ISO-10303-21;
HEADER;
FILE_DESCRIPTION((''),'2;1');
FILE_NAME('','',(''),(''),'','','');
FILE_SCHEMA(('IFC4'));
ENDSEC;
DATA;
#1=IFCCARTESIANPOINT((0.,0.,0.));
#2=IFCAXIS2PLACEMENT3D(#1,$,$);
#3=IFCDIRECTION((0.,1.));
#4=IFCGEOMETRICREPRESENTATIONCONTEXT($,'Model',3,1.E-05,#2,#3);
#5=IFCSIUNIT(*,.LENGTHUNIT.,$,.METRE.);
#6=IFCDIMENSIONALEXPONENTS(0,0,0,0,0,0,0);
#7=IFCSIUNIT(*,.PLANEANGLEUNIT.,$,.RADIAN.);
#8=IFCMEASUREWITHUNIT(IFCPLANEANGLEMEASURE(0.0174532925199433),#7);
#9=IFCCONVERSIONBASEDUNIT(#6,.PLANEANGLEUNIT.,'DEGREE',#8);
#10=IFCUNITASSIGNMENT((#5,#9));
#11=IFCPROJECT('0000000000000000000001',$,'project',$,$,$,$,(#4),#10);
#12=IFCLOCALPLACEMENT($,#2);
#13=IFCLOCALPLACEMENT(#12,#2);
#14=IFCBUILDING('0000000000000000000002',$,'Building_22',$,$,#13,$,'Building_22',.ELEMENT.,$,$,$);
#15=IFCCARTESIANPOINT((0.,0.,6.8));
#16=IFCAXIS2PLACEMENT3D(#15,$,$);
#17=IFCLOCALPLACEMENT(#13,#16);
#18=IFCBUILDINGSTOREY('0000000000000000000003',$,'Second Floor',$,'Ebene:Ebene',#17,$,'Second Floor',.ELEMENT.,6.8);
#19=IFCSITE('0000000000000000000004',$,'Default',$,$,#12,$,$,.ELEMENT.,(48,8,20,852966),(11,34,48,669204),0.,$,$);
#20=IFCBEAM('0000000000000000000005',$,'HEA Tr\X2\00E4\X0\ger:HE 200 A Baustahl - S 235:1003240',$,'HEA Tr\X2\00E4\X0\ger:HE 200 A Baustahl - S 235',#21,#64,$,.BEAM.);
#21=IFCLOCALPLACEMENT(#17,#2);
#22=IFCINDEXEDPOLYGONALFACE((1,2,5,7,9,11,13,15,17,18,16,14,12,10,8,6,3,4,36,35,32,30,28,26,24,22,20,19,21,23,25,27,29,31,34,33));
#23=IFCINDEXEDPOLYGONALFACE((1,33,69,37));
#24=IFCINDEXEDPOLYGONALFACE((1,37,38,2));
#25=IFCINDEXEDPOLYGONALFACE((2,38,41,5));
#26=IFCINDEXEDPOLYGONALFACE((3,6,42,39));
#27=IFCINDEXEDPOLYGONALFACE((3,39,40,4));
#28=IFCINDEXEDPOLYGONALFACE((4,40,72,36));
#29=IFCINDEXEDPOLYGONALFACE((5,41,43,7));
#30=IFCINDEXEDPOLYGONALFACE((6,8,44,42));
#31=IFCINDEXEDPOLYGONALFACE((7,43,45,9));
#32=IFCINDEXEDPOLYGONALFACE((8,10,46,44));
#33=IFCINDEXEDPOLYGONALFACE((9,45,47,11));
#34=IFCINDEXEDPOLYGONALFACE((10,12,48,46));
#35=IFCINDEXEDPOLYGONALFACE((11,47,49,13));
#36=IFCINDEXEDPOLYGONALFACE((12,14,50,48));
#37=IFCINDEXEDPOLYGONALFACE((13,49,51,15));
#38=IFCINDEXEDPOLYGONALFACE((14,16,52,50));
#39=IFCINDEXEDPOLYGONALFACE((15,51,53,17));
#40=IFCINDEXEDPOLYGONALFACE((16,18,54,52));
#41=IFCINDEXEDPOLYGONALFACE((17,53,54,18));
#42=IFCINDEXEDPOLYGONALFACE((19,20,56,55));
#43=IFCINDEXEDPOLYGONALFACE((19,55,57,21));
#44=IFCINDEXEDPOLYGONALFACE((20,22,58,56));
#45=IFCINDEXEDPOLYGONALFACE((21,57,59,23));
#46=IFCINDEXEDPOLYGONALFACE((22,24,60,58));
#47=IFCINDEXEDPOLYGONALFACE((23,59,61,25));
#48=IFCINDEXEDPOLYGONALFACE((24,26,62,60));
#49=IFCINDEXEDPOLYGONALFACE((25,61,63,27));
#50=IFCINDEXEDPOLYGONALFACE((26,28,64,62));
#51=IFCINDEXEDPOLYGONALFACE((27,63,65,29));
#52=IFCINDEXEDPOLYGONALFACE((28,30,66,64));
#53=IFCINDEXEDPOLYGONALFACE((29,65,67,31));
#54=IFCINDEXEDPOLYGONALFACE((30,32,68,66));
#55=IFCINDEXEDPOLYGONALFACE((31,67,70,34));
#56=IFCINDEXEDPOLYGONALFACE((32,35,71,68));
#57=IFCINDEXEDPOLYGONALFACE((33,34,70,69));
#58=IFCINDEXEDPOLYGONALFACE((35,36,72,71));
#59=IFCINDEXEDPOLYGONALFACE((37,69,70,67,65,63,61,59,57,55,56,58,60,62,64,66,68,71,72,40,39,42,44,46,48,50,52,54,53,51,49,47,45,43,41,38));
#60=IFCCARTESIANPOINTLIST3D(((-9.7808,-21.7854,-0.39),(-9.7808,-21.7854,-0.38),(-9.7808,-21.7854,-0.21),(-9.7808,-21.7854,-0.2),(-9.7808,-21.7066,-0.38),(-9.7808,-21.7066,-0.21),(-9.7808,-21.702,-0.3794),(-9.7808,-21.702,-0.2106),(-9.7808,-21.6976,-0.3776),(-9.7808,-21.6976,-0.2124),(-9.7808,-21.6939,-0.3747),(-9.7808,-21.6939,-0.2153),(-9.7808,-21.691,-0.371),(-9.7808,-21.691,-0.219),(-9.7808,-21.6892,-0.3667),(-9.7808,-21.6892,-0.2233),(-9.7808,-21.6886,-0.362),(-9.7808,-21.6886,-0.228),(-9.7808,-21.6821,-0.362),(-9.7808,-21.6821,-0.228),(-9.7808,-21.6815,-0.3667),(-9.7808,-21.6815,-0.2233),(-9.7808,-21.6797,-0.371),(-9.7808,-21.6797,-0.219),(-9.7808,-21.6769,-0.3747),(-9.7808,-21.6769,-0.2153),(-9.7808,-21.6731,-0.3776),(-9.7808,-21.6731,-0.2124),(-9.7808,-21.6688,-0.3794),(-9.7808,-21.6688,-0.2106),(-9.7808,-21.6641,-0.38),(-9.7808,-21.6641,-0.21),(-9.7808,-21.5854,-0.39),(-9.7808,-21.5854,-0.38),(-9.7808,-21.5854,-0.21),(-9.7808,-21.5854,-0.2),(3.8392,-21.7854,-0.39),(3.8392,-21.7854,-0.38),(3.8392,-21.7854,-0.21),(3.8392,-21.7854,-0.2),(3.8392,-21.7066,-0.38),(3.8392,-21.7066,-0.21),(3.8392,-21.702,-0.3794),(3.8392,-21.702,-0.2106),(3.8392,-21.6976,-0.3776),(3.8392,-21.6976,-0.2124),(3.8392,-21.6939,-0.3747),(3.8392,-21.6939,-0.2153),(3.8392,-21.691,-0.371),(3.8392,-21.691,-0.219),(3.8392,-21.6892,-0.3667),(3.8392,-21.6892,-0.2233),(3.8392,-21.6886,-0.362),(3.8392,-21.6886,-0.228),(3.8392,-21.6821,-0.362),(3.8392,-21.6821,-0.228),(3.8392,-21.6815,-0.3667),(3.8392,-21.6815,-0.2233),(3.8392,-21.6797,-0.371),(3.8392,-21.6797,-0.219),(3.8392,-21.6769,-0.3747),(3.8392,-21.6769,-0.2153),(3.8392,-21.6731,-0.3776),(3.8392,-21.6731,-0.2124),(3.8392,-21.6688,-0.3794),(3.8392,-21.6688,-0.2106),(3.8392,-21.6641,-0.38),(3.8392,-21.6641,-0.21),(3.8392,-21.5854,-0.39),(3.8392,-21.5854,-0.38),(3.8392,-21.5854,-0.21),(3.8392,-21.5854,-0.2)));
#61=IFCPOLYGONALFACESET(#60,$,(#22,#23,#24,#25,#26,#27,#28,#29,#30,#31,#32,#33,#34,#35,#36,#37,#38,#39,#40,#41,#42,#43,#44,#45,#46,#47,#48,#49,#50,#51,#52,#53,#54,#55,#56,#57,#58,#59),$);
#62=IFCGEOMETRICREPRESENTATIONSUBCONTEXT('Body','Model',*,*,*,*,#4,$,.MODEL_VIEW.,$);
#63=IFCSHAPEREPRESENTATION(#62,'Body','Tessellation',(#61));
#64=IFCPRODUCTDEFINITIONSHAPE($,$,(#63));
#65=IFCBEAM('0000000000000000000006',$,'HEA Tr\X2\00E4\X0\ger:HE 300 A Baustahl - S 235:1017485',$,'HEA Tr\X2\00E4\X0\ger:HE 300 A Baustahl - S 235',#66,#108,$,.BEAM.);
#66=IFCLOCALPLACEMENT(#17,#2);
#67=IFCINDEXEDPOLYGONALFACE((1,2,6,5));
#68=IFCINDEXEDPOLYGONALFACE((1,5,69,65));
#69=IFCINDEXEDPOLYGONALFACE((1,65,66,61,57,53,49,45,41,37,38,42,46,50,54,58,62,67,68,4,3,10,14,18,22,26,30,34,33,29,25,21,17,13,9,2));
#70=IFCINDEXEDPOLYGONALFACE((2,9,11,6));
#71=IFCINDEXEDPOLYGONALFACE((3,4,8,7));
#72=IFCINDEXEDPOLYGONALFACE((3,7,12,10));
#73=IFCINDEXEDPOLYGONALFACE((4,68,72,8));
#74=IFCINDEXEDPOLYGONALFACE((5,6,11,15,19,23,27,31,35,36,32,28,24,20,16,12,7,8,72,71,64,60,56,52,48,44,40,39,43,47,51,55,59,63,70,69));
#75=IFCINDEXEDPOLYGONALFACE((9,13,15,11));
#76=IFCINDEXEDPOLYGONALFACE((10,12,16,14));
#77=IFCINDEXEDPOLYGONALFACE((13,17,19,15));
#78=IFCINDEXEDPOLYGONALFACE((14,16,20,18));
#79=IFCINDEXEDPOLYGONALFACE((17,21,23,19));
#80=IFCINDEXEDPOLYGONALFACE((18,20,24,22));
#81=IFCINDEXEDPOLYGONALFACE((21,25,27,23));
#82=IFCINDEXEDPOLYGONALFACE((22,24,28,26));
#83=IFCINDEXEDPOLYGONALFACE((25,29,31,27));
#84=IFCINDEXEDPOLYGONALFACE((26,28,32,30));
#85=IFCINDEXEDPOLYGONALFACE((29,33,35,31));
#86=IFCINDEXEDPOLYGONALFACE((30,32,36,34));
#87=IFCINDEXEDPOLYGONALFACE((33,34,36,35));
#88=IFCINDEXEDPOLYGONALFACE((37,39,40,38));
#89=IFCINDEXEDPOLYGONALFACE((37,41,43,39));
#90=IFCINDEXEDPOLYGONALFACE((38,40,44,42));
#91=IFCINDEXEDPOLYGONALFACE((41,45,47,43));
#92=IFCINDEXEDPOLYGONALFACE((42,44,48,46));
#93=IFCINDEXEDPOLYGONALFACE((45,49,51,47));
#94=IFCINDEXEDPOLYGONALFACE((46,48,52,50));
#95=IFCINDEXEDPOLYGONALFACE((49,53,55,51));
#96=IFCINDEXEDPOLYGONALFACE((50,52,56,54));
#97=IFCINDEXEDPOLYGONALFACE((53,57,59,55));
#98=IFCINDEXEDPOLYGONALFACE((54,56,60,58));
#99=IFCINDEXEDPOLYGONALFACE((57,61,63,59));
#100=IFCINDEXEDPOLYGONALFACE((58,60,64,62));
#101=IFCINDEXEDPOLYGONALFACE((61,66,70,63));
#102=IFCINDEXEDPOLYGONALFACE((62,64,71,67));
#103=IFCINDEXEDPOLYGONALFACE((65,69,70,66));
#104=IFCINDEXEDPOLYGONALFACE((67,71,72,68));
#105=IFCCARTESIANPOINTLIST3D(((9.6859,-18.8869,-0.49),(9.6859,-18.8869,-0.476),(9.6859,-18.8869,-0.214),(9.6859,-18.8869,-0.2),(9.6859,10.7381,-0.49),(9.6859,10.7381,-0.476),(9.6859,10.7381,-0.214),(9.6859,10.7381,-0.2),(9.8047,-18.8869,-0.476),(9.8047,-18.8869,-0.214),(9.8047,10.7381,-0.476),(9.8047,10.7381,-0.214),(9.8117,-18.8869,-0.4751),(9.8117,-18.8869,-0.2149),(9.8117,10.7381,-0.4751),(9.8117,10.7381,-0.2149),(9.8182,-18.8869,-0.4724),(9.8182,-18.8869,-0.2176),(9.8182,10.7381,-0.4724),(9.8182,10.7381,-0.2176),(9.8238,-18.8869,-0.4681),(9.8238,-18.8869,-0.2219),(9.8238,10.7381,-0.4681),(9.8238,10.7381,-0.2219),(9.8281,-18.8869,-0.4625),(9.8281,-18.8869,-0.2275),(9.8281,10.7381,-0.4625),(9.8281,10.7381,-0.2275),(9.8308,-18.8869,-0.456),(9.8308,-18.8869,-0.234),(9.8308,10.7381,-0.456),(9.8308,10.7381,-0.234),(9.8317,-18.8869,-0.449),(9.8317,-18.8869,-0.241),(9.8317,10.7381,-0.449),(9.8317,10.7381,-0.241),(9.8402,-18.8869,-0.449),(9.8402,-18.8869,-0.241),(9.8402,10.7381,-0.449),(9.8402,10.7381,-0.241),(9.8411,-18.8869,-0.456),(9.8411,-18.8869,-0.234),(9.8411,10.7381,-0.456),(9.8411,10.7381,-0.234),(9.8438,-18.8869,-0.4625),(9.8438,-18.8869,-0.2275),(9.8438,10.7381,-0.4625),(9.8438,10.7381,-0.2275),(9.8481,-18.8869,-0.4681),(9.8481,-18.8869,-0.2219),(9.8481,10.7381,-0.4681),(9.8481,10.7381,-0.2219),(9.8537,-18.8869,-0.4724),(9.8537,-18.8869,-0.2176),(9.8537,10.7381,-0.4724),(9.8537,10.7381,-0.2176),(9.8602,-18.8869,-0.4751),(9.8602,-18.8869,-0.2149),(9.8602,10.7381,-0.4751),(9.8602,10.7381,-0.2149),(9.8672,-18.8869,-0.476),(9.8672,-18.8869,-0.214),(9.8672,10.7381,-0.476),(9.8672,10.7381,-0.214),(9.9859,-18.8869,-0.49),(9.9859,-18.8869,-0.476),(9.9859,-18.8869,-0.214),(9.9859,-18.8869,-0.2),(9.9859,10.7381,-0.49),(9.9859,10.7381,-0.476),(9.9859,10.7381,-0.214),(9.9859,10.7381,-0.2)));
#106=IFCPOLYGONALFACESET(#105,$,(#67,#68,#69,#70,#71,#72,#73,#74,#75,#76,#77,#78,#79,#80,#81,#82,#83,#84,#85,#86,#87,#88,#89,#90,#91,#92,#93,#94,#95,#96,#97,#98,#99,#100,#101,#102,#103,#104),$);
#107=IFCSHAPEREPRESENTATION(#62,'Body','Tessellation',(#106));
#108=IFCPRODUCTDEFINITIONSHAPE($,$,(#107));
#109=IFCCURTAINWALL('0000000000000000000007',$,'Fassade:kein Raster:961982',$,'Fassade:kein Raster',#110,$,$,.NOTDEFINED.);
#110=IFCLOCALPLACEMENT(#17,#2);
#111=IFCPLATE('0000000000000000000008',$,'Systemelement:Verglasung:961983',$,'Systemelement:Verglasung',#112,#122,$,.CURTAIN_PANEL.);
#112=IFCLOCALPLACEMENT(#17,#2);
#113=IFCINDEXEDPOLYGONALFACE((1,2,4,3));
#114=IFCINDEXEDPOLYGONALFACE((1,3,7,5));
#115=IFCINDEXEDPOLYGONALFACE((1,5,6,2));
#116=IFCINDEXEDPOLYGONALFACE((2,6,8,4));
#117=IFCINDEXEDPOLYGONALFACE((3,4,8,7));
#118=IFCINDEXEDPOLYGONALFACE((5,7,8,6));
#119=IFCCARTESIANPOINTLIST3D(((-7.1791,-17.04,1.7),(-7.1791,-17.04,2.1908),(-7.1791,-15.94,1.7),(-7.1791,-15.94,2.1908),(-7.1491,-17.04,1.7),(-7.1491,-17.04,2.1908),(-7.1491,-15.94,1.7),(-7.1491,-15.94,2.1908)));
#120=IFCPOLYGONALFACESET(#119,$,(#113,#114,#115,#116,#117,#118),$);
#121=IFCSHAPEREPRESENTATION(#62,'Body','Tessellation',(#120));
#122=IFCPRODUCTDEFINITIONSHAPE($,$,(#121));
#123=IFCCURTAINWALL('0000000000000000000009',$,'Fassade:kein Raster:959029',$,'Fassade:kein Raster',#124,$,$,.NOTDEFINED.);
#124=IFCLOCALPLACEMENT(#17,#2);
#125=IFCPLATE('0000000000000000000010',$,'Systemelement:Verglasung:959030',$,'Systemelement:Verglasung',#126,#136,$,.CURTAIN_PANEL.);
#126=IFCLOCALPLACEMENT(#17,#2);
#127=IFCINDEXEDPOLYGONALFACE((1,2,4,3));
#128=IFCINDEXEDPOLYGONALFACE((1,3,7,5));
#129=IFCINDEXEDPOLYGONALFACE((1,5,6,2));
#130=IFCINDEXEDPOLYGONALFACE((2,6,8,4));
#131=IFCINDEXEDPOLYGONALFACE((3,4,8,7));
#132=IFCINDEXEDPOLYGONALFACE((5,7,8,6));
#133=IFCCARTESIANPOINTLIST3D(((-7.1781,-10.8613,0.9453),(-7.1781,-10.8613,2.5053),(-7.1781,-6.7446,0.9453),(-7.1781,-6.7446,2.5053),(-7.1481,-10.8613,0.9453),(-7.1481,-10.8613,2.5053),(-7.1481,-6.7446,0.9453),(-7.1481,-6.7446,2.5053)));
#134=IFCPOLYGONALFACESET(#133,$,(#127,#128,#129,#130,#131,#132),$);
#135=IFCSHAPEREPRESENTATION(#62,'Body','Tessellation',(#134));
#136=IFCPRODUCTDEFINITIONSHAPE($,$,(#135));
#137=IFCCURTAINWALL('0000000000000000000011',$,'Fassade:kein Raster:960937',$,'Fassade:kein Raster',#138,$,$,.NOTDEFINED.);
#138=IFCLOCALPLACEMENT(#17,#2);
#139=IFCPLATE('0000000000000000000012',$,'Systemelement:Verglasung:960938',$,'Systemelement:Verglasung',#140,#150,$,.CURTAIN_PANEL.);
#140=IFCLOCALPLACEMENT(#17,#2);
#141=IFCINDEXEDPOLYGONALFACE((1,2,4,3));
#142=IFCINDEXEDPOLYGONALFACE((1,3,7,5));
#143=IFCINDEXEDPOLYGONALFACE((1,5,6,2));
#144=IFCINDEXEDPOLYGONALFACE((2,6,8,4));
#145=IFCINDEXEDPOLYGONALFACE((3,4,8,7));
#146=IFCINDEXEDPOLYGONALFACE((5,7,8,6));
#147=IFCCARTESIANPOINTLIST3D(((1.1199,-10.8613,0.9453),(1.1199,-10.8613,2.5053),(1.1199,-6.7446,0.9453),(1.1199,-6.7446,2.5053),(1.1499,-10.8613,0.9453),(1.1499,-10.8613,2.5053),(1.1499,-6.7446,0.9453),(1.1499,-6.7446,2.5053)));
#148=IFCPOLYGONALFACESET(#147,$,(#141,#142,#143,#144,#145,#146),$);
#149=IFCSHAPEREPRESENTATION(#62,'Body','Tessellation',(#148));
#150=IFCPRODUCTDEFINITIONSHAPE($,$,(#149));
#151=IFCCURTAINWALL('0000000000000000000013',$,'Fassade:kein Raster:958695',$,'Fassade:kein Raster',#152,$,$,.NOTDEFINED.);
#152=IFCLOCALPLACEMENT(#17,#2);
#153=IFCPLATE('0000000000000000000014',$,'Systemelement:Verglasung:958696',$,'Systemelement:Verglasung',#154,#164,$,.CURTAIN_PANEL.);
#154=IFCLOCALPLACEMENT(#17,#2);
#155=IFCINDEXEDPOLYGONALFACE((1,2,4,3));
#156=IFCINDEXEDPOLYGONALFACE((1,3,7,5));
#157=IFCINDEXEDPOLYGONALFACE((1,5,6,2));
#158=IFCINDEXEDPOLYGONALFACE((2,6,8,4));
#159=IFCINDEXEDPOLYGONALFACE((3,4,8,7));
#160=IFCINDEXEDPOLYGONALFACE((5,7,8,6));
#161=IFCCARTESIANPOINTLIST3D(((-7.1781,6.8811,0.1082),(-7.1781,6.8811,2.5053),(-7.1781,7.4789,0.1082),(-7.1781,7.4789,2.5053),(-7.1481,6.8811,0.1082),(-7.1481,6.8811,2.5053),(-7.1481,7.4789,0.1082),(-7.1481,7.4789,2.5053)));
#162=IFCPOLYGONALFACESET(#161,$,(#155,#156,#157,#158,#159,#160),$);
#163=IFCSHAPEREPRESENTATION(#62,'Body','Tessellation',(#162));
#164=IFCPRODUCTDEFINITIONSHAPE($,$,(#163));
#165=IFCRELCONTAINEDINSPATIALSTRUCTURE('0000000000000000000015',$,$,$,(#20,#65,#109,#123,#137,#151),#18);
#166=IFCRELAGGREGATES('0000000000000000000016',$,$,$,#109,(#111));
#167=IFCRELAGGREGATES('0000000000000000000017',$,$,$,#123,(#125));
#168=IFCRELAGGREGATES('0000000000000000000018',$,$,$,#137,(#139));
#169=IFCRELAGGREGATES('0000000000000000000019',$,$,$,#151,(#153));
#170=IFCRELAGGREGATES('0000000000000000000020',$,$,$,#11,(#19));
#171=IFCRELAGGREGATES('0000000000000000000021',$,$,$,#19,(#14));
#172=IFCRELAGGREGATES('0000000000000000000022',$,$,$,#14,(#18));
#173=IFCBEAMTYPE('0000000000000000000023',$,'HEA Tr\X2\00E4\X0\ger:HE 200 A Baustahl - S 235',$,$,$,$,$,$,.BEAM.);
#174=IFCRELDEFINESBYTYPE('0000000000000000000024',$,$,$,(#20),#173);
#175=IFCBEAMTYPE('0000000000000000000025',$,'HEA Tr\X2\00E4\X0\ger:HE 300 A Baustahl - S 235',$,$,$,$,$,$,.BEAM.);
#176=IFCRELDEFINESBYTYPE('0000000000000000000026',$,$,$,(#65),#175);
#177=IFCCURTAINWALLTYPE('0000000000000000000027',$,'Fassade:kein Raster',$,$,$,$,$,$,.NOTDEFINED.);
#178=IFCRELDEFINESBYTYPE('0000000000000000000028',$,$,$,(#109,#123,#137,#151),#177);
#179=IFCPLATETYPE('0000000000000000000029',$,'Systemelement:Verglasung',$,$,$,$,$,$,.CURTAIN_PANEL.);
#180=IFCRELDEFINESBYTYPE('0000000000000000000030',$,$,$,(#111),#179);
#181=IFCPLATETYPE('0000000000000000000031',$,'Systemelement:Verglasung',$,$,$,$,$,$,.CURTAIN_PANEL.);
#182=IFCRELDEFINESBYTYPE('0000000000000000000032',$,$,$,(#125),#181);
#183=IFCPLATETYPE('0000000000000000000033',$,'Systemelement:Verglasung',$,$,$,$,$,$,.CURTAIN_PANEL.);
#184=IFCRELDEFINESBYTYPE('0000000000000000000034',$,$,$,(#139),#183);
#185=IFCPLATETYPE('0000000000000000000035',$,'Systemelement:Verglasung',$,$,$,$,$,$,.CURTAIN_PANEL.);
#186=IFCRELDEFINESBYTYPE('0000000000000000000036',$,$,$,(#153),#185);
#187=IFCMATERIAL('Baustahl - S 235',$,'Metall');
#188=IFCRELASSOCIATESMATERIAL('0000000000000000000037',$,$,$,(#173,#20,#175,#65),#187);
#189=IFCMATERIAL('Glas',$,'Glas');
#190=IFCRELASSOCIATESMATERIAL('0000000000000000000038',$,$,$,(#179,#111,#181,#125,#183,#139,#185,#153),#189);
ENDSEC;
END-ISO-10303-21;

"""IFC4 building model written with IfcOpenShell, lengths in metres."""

from ifc_helpers import new_model, entity, si_unit, converted_unit, direction, frame, origin, place, context, subcontext, project, spatial, line, arc, indexed_curve, outline, extrude, source, transform, mapped, material, type_object, type_shapes, element, aggregate, save


model = new_model("IFC4")

# Units and contexts
model_context = context("Model", 3, precision=1e-05, world=origin(), true_north=direction((0.0, 1.0)))
body_context = subcontext(model_context, "Body", "Model", "MODEL_VIEW")
ifc_project = project(units=[si_unit("LENGTHUNIT", "METRE"), converted_unit("PLANEANGLEUNIT", "DEGREE", entity("IfcPlaneAngleMeasure", 0.0174532925199433), si_unit("PLANEANGLEUNIT", "RADIAN"), dimensions=[0, 0, 0, 0, 0, 0, 0])], contexts=[model_context])

# Site, building, storey
site_placement = place(None, origin())
site = spatial("IfcSite", under=ifc_project, at=site_placement, Name="Default", CompositionType="ELEMENT", RefLatitude=(48, 8, 20, 852966), RefLongitude=(11, 34, 48, 669204), RefElevation=0.0)
building_placement = place(site_placement, origin())
building = spatial("IfcBuilding", under=site, at=building_placement, Name="Building_22", LongName="Building_22", CompositionType="ELEMENT")
storey_placement = place(building_placement, frame((0.0, 0.0, 6.8)))
storey = spatial("IfcBuildingStorey", under=building, at=storey_placement, Name="Second Floor", ObjectType="Ebene:Ebene", LongName="Second Floor", CompositionType="ELEMENT", Elevation=6.8)

# Beams
ifc_material_1 = material(Name="Baustahl - S 235", Category="Metall")
beam_type_1 = type_object("IfcBeamType", Name="HEA Träger:HE 200 A Baustahl - S 235", PredefinedType="BEAM", material=ifc_material_1)
shared_shape_1 = source(origin(), body_context, "Body", "SweptSolid", [
    extrude(outline(indexed_curve([(-0.1, -0.085), (-0.1, -0.095), (0.1, -0.095), (0.1, -0.085), (0.0213, -0.085), (0.0085, -0.0797), (0.0033, -0.067), (0.0033, 0.067), (0.0085, 0.0797), (0.0213, 0.085), (0.1, 0.085), (0.1, 0.095), (-0.1, 0.095), (-0.1, 0.085), (-0.0213, 0.085), (-0.0085, 0.0797), (-0.0033, 0.067), (-0.0033, -0.067), (-0.0085, -0.0797), (-0.0213, -0.085)], segments=[line(1, 2, 3, 4, 5), arc(5, 6, 7), line(7, 8), arc(8, 9, 10), line(10, 11, 12, 13, 14, 15), arc(15, 16, 17), line(17, 18), arc(18, 19, 20), line(20, 1)], self_intersect=False)), frame((-6.81, 0.0, 0.0), z_axis=(-1.0, 0.0, 0.0), x_axis=(0.0, -1.0, 0.0)), (0.0, 0.0, -1.0), 13.62),
])
type_shapes(beam_type_1, [shared_shape_1])
beam_1_placement = place(storey_placement, frame((-2.9708, -21.6854, -0.295)))
element("IfcBeam", 1, at=beam_1_placement, inside=storey, type_object=beam_type_1, material=ifc_material_1, Name="HEA Träger:HE 200 A Baustahl - S 235:1003240", ObjectType="HEA Träger:HE 200 A Baustahl - S 235", PredefinedType="BEAM", context=body_context, shape_type="MappedRepresentation", body=[
    mapped(shared_shape_1, transform((0.0, 0.0, 0.0), scale=1.0)),
])
beam_type_2 = type_object("IfcBeamType", Name="HEA Träger:HE 300 A Baustahl - S 235", PredefinedType="BEAM", material=ifc_material_1)
shared_shape_2 = source(origin(), body_context, "Body", "SweptSolid", [
    extrude(outline(indexed_curve([(0.131, -0.15), (0.145, -0.15), (0.145, 0.15), (0.131, 0.15), (0.131, 0.0313), (0.1231, 0.0122), (0.104, 0.0043), (-0.104, 0.0043), (-0.1231, 0.0122), (-0.131, 0.0313), (-0.131, 0.15), (-0.145, 0.15), (-0.145, -0.15), (-0.131, -0.15), (-0.131, -0.0313), (-0.1231, -0.0122), (-0.104, -0.0043), (0.104, -0.0043), (0.1231, -0.0122), (0.131, -0.0313)], segments=[line(1, 2, 3, 4, 5), arc(5, 6, 7), line(7, 8), arc(8, 9, 10), line(10, 11, 12, 13, 14, 15), arc(15, 16, 17), line(17, 18), arc(18, 19, 20), line(20, 1)], self_intersect=False)), frame((-14.8125, 0.0, 0.0), z_axis=(1.0, 0.0, 0.0), x_axis=(0.0, 0.0, -1.0)), (0.0, 0.0, 1.0), 29.625),
])
type_shapes(beam_type_2, [shared_shape_2])
beam_2_placement = place(storey_placement, frame((9.8359, -4.0744, -0.345), z_axis=(0.0, 0.0, 1.0), x_axis=(0.0, -1.0, 0.0)))
element("IfcBeam", 2, at=beam_2_placement, inside=storey, type_object=beam_type_2, material=ifc_material_1, Name="HEA Träger:HE 300 A Baustahl - S 235:1017485", ObjectType="HEA Träger:HE 300 A Baustahl - S 235", PredefinedType="BEAM", context=body_context, shape_type="MappedRepresentation", body=[
    mapped(shared_shape_2, transform((0.0, 0.0, 0.0), scale=1.0)),
])

# Curtain walls, plates
curtain_wall_type_1 = type_object("IfcCurtainWallType", Name="Fassade:kein Raster", PredefinedType="NOTDEFINED")
curtain_wall_1_placement = place(storey_placement, frame((0.0, 0.0, -6.8)))
curtain_wall_1 = element("IfcCurtainWall", 3, at=curtain_wall_1_placement, inside=storey, type_object=curtain_wall_type_1, Name="Fassade:kein Raster:961982", ObjectType="Fassade:kein Raster", PredefinedType="NOTDEFINED")
ifc_material_2 = material(Name="Glas", Category="Glas")
plate_type_1 = type_object("IfcPlateType", Name="Systemelement:Verglasung", PredefinedType="CURTAIN_PANEL", material=ifc_material_2)
shared_shape_3 = source(origin(), body_context, "Body", "SweptSolid", [
    extrude(outline(indexed_curve([(-0.015, -0.55), (0.015, -0.55), (0.015, 0.55), (-0.015, 0.55), (-0.015, -0.55)], self_intersect=False)), frame((0.0, 0.0, 0.0), z_axis=(0.0, 0.0, 1.0), x_axis=(0.0, 1.0, 0.0)), (0.0, 0.0, 1.0), 0.4908),
])
type_shapes(plate_type_1, [shared_shape_3])
plate_1_placement = place(curtain_wall_1_placement, frame((-7.1641, -16.49, 8.5), z_axis=(0.0, 0.0, 1.0), x_axis=(0.0, -1.0, 0.0)))
plate_1 = element("IfcPlate", 4, at=plate_1_placement, type_object=plate_type_1, material=ifc_material_2, Name="Systemelement:Verglasung:961983", ObjectType="Systemelement:Verglasung", PredefinedType="CURTAIN_PANEL", context=body_context, shape_type="MappedRepresentation", body=[
    mapped(shared_shape_3, transform((0.0, 0.0, 0.0), scale=1.0)),
])
aggregate(curtain_wall_1, [plate_1])
curtain_wall_2_placement = place(storey_placement, frame((0.0, 0.0, -6.8)))
curtain_wall_2 = element("IfcCurtainWall", 5, at=curtain_wall_2_placement, inside=storey, type_object=curtain_wall_type_1, Name="Fassade:kein Raster:959029", ObjectType="Fassade:kein Raster", PredefinedType="NOTDEFINED")
plate_type_2 = type_object("IfcPlateType", Name="Systemelement:Verglasung", PredefinedType="CURTAIN_PANEL", material=ifc_material_2)
shared_shape_4 = source(origin(), body_context, "Body", "SweptSolid", [
    extrude(outline(indexed_curve([(-0.015, -2.0583), (0.015, -2.0583), (0.015, 2.0583), (-0.015, 2.0583), (-0.015, -2.0583)], self_intersect=False)), frame((0.0, 0.0, 0.0), z_axis=(0.0, 0.0, 1.0), x_axis=(0.0, 1.0, 0.0)), (0.0, 0.0, 1.0), 1.56),
])
type_shapes(plate_type_2, [shared_shape_4])
plate_2_placement = place(curtain_wall_2_placement, frame((-7.1631, -8.8029, 7.7453), z_axis=(0.0, 0.0, 1.0), x_axis=(0.0, -1.0, 0.0)))
plate_2 = element("IfcPlate", 6, at=plate_2_placement, type_object=plate_type_2, material=ifc_material_2, Name="Systemelement:Verglasung:959030", ObjectType="Systemelement:Verglasung", PredefinedType="CURTAIN_PANEL", context=body_context, shape_type="MappedRepresentation", body=[
    mapped(shared_shape_4, transform((0.0, 0.0, 0.0), scale=1.0)),
])
aggregate(curtain_wall_2, [plate_2])
curtain_wall_3_placement = place(storey_placement, frame((0.0, 0.0, -6.8)))
curtain_wall_3 = element("IfcCurtainWall", 7, at=curtain_wall_3_placement, inside=storey, type_object=curtain_wall_type_1, Name="Fassade:kein Raster:960937", ObjectType="Fassade:kein Raster", PredefinedType="NOTDEFINED")
plate_type_3 = type_object("IfcPlateType", Name="Systemelement:Verglasung", PredefinedType="CURTAIN_PANEL", material=ifc_material_2)
shared_shape_5 = source(origin(), body_context, "Body", "SweptSolid", [
    extrude(outline(indexed_curve([(-0.015, -2.0583), (0.015, -2.0583), (0.015, 2.0583), (-0.015, 2.0583), (-0.015, -2.0583)], self_intersect=False)), frame((0.0, 0.0, 0.0), z_axis=(0.0, 0.0, 1.0), x_axis=(0.0, 1.0, 0.0)), (0.0, 0.0, 1.0), 1.56),
])
type_shapes(plate_type_3, [shared_shape_5])
plate_3_placement = place(curtain_wall_3_placement, frame((1.1349, -8.8029, 7.7453), z_axis=(0.0, 0.0, 1.0), x_axis=(0.0, -1.0, 0.0)))
plate_3 = element("IfcPlate", 8, at=plate_3_placement, type_object=plate_type_3, material=ifc_material_2, Name="Systemelement:Verglasung:960938", ObjectType="Systemelement:Verglasung", PredefinedType="CURTAIN_PANEL", context=body_context, shape_type="MappedRepresentation", body=[
    mapped(shared_shape_5, transform((0.0, 0.0, 0.0), scale=1.0)),
])
aggregate(curtain_wall_3, [plate_3])
curtain_wall_4_placement = place(storey_placement, frame((0.0, 0.0, -6.8)))
curtain_wall_4 = element("IfcCurtainWall", 9, at=curtain_wall_4_placement, inside=storey, type_object=curtain_wall_type_1, Name="Fassade:kein Raster:958695", ObjectType="Fassade:kein Raster", PredefinedType="NOTDEFINED")
plate_type_4 = type_object("IfcPlateType", Name="Systemelement:Verglasung", PredefinedType="CURTAIN_PANEL", material=ifc_material_2)
shared_shape_6 = source(origin(), body_context, "Body", "SweptSolid", [
    extrude(outline(indexed_curve([(-0.015, -0.2989), (0.015, -0.2989), (0.015, 0.2989), (-0.015, 0.2989), (-0.015, -0.2989)], self_intersect=False)), frame((0.0, 0.0, 0.0), z_axis=(0.0, 0.0, 1.0), x_axis=(0.0, 1.0, 0.0)), (0.0, 0.0, 1.0), 2.3972),
])
type_shapes(plate_type_4, [shared_shape_6])
plate_4_placement = place(curtain_wall_4_placement, frame((-7.1631, 7.18, 6.9082), z_axis=(0.0, 0.0, 1.0), x_axis=(0.0, -1.0, 0.0)))
plate_4 = element("IfcPlate", 10, at=plate_4_placement, type_object=plate_type_4, material=ifc_material_2, Name="Systemelement:Verglasung:958696", ObjectType="Systemelement:Verglasung", PredefinedType="CURTAIN_PANEL", context=body_context, shape_type="MappedRepresentation", body=[
    mapped(shared_shape_6, transform((0.0, 0.0, 0.0), scale=1.0)),
])
aggregate(curtain_wall_4, [plate_4])

save(model, "model.ifc")
